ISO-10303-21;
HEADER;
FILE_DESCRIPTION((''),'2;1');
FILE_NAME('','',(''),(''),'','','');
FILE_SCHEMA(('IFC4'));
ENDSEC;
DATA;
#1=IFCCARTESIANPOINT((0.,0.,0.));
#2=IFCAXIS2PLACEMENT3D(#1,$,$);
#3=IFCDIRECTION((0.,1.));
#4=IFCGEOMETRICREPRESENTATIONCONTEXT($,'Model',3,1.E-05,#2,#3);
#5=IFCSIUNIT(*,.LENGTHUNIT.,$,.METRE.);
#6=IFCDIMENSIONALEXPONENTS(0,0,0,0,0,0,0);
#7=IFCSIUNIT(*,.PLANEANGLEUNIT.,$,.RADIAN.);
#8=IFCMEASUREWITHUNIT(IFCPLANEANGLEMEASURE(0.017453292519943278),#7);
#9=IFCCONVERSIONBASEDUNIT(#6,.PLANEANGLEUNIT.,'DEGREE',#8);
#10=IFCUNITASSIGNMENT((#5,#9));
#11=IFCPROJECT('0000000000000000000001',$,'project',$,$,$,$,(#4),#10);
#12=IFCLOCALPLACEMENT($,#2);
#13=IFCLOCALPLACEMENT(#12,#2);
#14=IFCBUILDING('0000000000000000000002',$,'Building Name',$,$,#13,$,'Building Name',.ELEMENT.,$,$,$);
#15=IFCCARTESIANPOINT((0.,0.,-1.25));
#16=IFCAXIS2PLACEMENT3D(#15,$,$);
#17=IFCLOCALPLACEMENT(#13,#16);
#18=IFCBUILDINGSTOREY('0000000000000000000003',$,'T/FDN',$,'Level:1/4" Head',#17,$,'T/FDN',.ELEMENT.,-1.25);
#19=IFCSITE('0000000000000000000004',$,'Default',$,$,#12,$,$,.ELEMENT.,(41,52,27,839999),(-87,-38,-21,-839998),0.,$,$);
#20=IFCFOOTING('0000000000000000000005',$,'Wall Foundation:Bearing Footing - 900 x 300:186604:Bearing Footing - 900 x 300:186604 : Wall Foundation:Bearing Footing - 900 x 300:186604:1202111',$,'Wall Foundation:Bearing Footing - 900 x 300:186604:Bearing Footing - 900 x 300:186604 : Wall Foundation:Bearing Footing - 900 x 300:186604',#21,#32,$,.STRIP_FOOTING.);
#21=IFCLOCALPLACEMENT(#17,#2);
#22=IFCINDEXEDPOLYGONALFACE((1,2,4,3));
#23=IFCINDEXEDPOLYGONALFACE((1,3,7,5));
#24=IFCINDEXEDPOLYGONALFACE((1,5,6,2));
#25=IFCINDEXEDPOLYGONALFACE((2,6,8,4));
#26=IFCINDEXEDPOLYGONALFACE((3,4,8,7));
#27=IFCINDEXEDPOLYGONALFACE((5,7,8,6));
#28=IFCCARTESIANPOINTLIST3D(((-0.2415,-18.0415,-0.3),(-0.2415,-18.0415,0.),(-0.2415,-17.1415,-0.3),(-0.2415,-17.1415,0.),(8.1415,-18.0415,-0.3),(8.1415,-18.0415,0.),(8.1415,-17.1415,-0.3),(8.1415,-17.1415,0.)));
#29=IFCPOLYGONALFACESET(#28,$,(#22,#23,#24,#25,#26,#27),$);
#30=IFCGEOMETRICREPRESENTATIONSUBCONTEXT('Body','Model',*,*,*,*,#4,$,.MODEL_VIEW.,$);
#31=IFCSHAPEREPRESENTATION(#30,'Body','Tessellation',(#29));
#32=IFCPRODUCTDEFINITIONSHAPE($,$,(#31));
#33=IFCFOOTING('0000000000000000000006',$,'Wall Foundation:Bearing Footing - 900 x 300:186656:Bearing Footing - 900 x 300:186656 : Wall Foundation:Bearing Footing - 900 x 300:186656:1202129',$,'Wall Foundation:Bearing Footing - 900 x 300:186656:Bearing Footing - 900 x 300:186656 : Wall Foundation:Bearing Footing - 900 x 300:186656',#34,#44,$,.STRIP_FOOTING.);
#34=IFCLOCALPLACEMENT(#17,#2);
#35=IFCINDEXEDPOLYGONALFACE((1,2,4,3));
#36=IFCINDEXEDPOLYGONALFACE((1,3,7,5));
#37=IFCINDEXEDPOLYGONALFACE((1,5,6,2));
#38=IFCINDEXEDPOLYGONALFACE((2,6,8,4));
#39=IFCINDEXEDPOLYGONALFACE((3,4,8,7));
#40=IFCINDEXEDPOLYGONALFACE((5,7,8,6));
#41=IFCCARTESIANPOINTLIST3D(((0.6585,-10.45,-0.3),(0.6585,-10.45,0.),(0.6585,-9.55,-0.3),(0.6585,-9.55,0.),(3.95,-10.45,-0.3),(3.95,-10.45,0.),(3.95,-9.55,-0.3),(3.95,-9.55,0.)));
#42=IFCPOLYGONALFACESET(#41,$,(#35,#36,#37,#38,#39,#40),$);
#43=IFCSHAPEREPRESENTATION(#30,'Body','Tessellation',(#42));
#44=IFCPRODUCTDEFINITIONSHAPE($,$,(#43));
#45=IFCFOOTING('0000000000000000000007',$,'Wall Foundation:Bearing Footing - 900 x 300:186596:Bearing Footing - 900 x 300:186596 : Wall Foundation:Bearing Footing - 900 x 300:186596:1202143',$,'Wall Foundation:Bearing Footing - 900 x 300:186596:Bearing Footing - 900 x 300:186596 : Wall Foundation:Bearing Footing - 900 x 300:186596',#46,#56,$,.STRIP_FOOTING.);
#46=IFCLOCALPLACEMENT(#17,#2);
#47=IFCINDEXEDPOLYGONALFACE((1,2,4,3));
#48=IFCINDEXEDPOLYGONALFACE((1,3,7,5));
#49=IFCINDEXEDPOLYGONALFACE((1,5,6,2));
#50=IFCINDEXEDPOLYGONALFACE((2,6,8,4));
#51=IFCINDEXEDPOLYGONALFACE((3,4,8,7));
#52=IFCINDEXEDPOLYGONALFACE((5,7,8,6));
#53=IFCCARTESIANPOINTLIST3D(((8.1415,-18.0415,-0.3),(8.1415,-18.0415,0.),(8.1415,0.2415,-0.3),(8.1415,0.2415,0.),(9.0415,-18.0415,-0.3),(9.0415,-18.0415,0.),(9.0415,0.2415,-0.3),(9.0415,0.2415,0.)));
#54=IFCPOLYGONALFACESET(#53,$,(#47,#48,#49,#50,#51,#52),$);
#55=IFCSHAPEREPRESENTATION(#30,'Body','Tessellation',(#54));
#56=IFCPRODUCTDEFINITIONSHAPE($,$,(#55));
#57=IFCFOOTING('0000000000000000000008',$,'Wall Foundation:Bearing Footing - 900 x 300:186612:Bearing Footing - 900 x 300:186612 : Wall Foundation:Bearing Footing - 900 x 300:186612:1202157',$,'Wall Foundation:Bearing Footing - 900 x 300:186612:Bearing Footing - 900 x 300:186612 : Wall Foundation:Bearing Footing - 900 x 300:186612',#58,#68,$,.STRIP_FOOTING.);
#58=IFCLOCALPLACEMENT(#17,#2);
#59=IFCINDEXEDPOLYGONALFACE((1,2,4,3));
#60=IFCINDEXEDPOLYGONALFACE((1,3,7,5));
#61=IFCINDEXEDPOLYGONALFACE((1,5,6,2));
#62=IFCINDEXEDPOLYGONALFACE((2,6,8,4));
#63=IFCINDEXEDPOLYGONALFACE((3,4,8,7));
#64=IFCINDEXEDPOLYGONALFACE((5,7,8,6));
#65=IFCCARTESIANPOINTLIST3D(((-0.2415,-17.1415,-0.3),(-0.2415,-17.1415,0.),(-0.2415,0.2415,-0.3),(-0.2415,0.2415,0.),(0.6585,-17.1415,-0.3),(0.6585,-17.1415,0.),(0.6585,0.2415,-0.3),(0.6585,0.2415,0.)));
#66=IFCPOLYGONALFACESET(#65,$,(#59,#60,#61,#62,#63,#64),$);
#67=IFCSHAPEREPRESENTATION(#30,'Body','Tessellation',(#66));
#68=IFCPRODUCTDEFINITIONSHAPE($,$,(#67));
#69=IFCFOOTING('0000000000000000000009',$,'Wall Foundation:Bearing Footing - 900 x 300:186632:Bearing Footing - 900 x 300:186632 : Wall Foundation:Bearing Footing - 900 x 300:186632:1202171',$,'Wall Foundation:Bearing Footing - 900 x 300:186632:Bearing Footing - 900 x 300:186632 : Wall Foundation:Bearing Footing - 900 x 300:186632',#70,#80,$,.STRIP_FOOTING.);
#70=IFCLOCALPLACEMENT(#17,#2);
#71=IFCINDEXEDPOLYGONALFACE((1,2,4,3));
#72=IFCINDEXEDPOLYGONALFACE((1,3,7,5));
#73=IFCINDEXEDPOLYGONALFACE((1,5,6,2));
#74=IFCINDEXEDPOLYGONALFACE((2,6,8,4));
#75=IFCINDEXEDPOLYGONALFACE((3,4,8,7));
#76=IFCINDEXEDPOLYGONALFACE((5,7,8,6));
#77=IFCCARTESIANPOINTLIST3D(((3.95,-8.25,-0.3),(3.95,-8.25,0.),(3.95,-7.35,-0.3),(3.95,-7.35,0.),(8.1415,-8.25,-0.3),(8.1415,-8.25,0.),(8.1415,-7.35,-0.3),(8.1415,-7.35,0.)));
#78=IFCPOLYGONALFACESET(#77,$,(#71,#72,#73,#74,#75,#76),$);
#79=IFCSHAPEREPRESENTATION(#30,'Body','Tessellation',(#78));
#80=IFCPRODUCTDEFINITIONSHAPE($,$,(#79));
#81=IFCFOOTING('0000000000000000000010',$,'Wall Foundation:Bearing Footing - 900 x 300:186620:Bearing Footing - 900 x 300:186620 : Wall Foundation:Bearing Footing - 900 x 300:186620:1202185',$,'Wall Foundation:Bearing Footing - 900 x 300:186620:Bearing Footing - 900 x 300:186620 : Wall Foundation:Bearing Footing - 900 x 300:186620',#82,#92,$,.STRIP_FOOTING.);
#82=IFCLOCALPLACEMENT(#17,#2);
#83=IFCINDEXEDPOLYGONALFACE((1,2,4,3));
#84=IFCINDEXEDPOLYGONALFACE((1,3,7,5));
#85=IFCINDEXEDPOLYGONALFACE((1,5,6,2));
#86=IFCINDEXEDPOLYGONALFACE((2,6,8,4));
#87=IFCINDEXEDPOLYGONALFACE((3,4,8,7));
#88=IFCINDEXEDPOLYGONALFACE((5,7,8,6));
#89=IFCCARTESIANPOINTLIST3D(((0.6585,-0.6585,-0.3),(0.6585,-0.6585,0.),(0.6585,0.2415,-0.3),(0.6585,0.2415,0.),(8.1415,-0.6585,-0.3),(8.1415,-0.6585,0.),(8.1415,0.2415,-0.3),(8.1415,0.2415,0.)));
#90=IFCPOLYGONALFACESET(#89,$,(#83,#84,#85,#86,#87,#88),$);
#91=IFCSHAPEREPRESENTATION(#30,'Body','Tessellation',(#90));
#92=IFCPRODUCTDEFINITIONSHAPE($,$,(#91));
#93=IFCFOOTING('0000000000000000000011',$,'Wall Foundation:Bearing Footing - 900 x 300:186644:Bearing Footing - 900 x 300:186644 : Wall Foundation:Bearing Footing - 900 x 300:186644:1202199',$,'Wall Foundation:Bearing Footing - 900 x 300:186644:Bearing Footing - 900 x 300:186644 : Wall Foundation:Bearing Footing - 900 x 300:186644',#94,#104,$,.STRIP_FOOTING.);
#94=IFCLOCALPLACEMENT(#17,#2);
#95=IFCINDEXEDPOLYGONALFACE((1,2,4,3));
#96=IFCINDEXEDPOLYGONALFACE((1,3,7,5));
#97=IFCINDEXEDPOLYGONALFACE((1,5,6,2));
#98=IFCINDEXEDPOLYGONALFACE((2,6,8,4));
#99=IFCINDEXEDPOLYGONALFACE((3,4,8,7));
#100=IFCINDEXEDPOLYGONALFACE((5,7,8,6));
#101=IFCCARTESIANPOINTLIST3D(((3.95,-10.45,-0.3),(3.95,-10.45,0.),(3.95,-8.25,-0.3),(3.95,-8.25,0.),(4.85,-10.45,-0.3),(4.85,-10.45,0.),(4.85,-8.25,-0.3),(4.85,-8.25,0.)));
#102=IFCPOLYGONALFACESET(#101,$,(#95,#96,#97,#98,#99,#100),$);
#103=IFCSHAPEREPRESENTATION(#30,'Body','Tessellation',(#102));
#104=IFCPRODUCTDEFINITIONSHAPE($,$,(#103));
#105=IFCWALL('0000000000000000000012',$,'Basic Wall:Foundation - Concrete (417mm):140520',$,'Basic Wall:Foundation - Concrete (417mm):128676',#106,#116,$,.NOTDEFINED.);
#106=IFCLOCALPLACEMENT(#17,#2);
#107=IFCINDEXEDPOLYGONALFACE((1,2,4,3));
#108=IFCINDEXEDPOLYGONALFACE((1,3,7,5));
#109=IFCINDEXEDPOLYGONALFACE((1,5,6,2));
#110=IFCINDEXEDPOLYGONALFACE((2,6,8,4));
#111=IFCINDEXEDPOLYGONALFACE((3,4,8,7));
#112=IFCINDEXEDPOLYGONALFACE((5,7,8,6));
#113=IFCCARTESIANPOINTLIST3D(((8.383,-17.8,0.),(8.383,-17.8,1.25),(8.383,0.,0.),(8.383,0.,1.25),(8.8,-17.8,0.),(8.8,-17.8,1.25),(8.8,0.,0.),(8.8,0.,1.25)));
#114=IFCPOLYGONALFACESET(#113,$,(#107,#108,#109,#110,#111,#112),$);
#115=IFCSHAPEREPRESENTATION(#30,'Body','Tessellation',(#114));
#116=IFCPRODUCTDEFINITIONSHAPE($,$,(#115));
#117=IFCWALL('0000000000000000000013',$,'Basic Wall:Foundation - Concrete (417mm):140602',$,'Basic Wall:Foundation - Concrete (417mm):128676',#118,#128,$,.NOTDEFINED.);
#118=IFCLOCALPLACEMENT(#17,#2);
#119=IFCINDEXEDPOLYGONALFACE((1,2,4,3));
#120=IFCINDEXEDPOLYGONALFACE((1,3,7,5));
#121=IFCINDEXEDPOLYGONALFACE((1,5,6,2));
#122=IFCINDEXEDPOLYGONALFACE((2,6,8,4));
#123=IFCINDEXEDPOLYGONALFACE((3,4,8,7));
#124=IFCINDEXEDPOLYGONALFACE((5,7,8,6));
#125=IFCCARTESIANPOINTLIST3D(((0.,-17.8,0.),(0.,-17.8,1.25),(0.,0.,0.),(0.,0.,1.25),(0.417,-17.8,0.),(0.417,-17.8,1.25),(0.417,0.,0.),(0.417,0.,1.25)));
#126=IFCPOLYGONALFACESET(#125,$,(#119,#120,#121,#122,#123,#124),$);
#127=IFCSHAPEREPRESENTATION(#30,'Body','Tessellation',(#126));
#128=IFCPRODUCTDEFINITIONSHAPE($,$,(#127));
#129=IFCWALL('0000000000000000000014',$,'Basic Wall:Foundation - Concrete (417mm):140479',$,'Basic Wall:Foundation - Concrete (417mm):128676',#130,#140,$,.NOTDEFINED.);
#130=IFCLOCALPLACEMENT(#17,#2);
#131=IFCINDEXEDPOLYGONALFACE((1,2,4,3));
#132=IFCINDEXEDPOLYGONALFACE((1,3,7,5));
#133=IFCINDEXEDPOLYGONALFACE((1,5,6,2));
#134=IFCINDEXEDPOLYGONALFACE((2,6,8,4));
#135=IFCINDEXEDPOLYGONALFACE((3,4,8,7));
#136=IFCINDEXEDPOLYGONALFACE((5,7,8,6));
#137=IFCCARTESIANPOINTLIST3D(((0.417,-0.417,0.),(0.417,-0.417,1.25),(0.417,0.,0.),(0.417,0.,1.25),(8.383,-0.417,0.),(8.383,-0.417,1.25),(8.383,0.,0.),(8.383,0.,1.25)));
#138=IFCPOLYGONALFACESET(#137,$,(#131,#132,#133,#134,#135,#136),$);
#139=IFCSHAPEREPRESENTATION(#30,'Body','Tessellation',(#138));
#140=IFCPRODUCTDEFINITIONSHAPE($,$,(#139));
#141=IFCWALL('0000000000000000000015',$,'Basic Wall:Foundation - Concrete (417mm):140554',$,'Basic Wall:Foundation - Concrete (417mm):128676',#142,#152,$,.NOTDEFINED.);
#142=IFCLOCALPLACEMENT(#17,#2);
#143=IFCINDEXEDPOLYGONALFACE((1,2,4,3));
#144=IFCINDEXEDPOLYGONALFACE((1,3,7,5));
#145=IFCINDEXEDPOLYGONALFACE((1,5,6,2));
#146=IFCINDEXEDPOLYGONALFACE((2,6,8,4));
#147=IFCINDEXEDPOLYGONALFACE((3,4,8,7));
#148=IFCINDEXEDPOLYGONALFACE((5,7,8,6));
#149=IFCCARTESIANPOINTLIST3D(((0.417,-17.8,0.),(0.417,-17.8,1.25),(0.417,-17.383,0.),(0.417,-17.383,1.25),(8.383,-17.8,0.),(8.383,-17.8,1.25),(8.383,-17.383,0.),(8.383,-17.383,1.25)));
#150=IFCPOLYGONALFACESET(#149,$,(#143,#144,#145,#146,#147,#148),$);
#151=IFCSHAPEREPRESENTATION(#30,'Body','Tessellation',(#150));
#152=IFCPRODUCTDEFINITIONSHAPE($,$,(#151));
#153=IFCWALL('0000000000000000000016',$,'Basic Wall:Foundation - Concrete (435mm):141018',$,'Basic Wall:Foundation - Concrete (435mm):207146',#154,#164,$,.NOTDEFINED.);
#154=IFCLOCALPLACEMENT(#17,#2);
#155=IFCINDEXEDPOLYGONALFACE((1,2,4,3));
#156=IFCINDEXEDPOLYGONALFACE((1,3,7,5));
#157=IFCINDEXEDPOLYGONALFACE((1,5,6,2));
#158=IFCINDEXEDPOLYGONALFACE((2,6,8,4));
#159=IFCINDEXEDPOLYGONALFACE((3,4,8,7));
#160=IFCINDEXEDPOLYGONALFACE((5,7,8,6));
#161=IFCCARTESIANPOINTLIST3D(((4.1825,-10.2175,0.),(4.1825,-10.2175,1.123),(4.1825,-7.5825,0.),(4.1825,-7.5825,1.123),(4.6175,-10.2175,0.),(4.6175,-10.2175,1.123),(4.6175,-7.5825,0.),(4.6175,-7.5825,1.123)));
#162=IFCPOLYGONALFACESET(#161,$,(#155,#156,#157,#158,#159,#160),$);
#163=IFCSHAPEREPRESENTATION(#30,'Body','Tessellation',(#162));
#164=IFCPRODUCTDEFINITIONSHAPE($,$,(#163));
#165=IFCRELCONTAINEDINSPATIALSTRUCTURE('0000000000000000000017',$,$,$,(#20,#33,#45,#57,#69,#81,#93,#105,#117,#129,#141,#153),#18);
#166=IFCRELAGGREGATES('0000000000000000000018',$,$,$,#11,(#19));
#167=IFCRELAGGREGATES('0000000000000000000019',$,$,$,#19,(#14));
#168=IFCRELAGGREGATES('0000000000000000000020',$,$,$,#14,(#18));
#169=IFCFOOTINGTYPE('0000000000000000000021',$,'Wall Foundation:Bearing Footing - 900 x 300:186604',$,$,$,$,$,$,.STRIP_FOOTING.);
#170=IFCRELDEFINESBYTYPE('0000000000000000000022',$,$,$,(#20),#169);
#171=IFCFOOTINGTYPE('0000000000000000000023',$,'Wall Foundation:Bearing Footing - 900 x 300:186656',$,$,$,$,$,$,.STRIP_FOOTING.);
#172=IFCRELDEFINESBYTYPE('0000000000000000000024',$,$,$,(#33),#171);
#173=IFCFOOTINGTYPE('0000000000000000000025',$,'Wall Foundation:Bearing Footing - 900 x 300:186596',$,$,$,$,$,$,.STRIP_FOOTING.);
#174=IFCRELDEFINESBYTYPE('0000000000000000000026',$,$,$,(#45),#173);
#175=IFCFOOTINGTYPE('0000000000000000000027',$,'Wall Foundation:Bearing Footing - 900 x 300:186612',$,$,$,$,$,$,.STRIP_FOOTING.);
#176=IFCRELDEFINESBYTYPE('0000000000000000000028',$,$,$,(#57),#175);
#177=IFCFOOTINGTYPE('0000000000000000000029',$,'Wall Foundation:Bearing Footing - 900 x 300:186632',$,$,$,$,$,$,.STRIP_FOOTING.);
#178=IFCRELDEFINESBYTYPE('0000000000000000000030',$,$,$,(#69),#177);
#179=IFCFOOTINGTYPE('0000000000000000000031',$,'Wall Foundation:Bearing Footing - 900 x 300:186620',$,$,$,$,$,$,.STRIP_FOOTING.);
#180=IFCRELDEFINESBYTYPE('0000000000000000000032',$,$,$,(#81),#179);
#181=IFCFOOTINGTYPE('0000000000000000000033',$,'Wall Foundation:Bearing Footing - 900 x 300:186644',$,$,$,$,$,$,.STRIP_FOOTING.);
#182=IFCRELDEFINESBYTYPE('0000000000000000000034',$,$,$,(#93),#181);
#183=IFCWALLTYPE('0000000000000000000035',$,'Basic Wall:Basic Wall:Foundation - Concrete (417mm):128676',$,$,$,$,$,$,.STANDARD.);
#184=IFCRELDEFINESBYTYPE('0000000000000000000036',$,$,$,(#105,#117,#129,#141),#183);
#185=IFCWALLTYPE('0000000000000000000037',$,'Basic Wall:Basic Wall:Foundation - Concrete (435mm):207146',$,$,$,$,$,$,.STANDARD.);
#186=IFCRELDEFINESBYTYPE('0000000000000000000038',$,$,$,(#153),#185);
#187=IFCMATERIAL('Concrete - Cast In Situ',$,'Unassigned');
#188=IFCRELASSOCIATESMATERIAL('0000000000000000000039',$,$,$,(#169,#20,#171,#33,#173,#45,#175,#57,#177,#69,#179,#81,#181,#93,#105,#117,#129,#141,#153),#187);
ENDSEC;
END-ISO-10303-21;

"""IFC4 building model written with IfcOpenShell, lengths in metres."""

from ifc_helpers import new_model, entity, si_unit, converted_unit, direction, frame, origin, place, context, subcontext, project, spatial, indexed_curve, outline, extrude, source, transform, mapped, material, type_object, type_shapes, element, save


model = new_model("IFC4")

# Units and contexts
model_context = context("Model", 3, precision=1e-05, world=origin(), true_north=direction((0.0, 1.0)))
body_context = subcontext(model_context, "Body", "Model", "MODEL_VIEW")
ifc_project = project(units=[si_unit("LENGTHUNIT", "METRE"), converted_unit("PLANEANGLEUNIT", "DEGREE", entity("IfcPlaneAngleMeasure", 0.017453292519943278), si_unit("PLANEANGLEUNIT", "RADIAN"), dimensions=[0, 0, 0, 0, 0, 0, 0])], contexts=[model_context])

# Site, building, storey
site_placement = place(None, origin())
site = spatial("IfcSite", under=ifc_project, at=site_placement, Name="Default", CompositionType="ELEMENT", RefLatitude=(41, 52, 27, 839999), RefLongitude=(-87, -38, -21, -839998), RefElevation=0.0)
building_placement = place(site_placement, origin())
building = spatial("IfcBuilding", under=site, at=building_placement, Name="Building Name", LongName="Building Name", CompositionType="ELEMENT")
storey_placement = place(building_placement, frame((0.0, 0.0, -1.25)))
storey = spatial("IfcBuildingStorey", under=building, at=storey_placement, Name="T/FDN", ObjectType="Level:1/4\" Head", LongName="T/FDN", CompositionType="ELEMENT", Elevation=-1.25)

# Footings
ifc_material = material(Name="Concrete - Cast In Situ", Category="Unassigned")
footing_type_1 = type_object("IfcFootingType", Name="Wall Foundation:Bearing Footing - 900 x 300:186604", PredefinedType="STRIP_FOOTING", material=ifc_material)
shared_shape_1 = source(origin(), body_context, "Body", "SweptSolid", [
    extrude(outline(indexed_curve([(-0.45, -4.1915), (0.45, -4.1915), (0.45, 4.1915), (-0.45, 4.1915), (-0.45, -4.1915)], self_intersect=False)), frame((3.95, -17.5915, -1.55), z_axis=(0.0, 0.0, 1.0), x_axis=(0.0, 1.0, 0.0)), (0.0, 0.0, 1.0), 0.3),
])
type_shapes(footing_type_1, [shared_shape_1])
footing_1_placement = place(storey_placement, frame((0.0, 0.0, 1.25)))
element("IfcFooting", 1, at=footing_1_placement, inside=storey, type_object=footing_type_1, material=ifc_material, Name="Wall Foundation:Bearing Footing - 900 x 300:186604:Bearing Footing - 900 x 300:186604 : Wall Foundation:Bearing Footing - 900 x 300:186604:1202111", ObjectType="Wall Foundation:Bearing Footing - 900 x 300:186604:Bearing Footing - 900 x 300:186604 : Wall Foundation:Bearing Footing - 900 x 300:186604", PredefinedType="STRIP_FOOTING", context=body_context, shape_type="MappedRepresentation", body=[
    mapped(shared_shape_1, transform((0.0, 0.0, 0.0), scale=1.0)),
])
footing_type_2 = type_object("IfcFootingType", Name="Wall Foundation:Bearing Footing - 900 x 300:186656", PredefinedType="STRIP_FOOTING", material=ifc_material)
shared_shape_2 = source(origin(), body_context, "Body", "SweptSolid", [
    extrude(outline(indexed_curve([(-0.45, -1.6457), (0.45, -1.6457), (0.45, 1.6457), (-0.45, 1.6457), (-0.45, -1.6457)], self_intersect=False)), frame((2.3042, -10.0, -1.55), z_axis=(0.0, 0.0, 1.0), x_axis=(0.0, 1.0, 0.0)), (0.0, 0.0, 1.0), 0.3),
])
type_shapes(footing_type_2, [shared_shape_2])
footing_2_placement = place(storey_placement, frame((0.0, 0.0, 1.25)))
element("IfcFooting", 2, at=footing_2_placement, inside=storey, type_object=footing_type_2, material=ifc_material, Name="Wall Foundation:Bearing Footing - 900 x 300:186656:Bearing Footing - 900 x 300:186656 : Wall Foundation:Bearing Footing - 900 x 300:186656:1202129", ObjectType="Wall Foundation:Bearing Footing - 900 x 300:186656:Bearing Footing - 900 x 300:186656 : Wall Foundation:Bearing Footing - 900 x 300:186656", PredefinedType="STRIP_FOOTING", context=body_context, shape_type="MappedRepresentation", body=[
    mapped(shared_shape_2, transform((0.0, 0.0, 0.0), scale=1.0)),
])
footing_type_3 = type_object("IfcFootingType", Name="Wall Foundation:Bearing Footing - 900 x 300:186596", PredefinedType="STRIP_FOOTING", material=ifc_material)
shared_shape_3 = source(origin(), body_context, "Body", "SweptSolid", [
    extrude(outline(indexed_curve([(-0.45, -9.1415), (0.45, -9.1415), (0.45, 9.1415), (-0.45, 9.1415), (-0.45, -9.1415)], self_intersect=False)), frame((8.5915, -8.9, -1.55)), (0.0, 0.0, 1.0), 0.3),
])
type_shapes(footing_type_3, [shared_shape_3])
footing_3_placement = place(storey_placement, frame((0.0, 0.0, 1.25)))
element("IfcFooting", 3, at=footing_3_placement, inside=storey, type_object=footing_type_3, material=ifc_material, Name="Wall Foundation:Bearing Footing - 900 x 300:186596:Bearing Footing - 900 x 300:186596 : Wall Foundation:Bearing Footing - 900 x 300:186596:1202143", ObjectType="Wall Foundation:Bearing Footing - 900 x 300:186596:Bearing Footing - 900 x 300:186596 : Wall Foundation:Bearing Footing - 900 x 300:186596", PredefinedType="STRIP_FOOTING", context=body_context, shape_type="MappedRepresentation", body=[
    mapped(shared_shape_3, transform((0.0, 0.0, 0.0), scale=1.0)),
])
footing_type_4 = type_object("IfcFootingType", Name="Wall Foundation:Bearing Footing - 900 x 300:186612", PredefinedType="STRIP_FOOTING", material=ifc_material)
shared_shape_4 = source(origin(), body_context, "Body", "SweptSolid", [
    extrude(outline(indexed_curve([(-0.45, -8.6915), (0.45, -8.6915), (0.45, 8.6915), (-0.45, 8.6915), (-0.45, -8.6915)], self_intersect=False)), frame((0.2085, -8.45, -1.55)), (0.0, 0.0, 1.0), 0.3),
])
type_shapes(footing_type_4, [shared_shape_4])
footing_4_placement = place(storey_placement, frame((0.0, 0.0, 1.25)))
element("IfcFooting", 4, at=footing_4_placement, inside=storey, type_object=footing_type_4, material=ifc_material, Name="Wall Foundation:Bearing Footing - 900 x 300:186612:Bearing Footing - 900 x 300:186612 : Wall Foundation:Bearing Footing - 900 x 300:186612:1202157", ObjectType="Wall Foundation:Bearing Footing - 900 x 300:186612:Bearing Footing - 900 x 300:186612 : Wall Foundation:Bearing Footing - 900 x 300:186612", PredefinedType="STRIP_FOOTING", context=body_context, shape_type="MappedRepresentation", body=[
    mapped(shared_shape_4, transform((0.0, 0.0, 0.0), scale=1.0)),
])
footing_type_5 = type_object("IfcFootingType", Name="Wall Foundation:Bearing Footing - 900 x 300:186632", PredefinedType="STRIP_FOOTING", material=ifc_material)
shared_shape_5 = source(origin(), body_context, "Body", "SweptSolid", [
    extrude(outline(indexed_curve([(-0.45, -2.0958), (0.45, -2.0958), (0.45, 2.0958), (-0.45, 2.0958), (-0.45, -2.0958)], self_intersect=False)), frame((6.0457, -7.8, -1.55), z_axis=(0.0, 0.0, 1.0), x_axis=(0.0, -1.0, 0.0)), (0.0, 0.0, 1.0), 0.3),
])
type_shapes(footing_type_5, [shared_shape_5])
footing_5_placement = place(storey_placement, frame((0.0, 0.0, 1.25)))
element("IfcFooting", 5, at=footing_5_placement, inside=storey, type_object=footing_type_5, material=ifc_material, Name="Wall Foundation:Bearing Footing - 900 x 300:186632:Bearing Footing - 900 x 300:186632 : Wall Foundation:Bearing Footing - 900 x 300:186632:1202171", ObjectType="Wall Foundation:Bearing Footing - 900 x 300:186632:Bearing Footing - 900 x 300:186632 : Wall Foundation:Bearing Footing - 900 x 300:186632", PredefinedType="STRIP_FOOTING", context=body_context, shape_type="MappedRepresentation", body=[
    mapped(shared_shape_5, transform((0.0, 0.0, 0.0), scale=1.0)),
])
footing_type_6 = type_object("IfcFootingType", Name="Wall Foundation:Bearing Footing - 900 x 300:186620", PredefinedType="STRIP_FOOTING", material=ifc_material)
shared_shape_6 = source(origin(), body_context, "Body", "SweptSolid", [
    extrude(outline(indexed_curve([(-0.45, -3.7415), (0.45, -3.7415), (0.45, 3.7415), (-0.45, 3.7415), (-0.45, -3.7415)], self_intersect=False)), frame((4.4, -0.2085, -1.55), z_axis=(0.0, 0.0, 1.0), x_axis=(0.0, -1.0, 0.0)), (0.0, 0.0, 1.0), 0.3),
])
type_shapes(footing_type_6, [shared_shape_6])
footing_6_placement = place(storey_placement, frame((0.0, 0.0, 1.25)))
element("IfcFooting", 6, at=footing_6_placement, inside=storey, type_object=footing_type_6, material=ifc_material, Name="Wall Foundation:Bearing Footing - 900 x 300:186620:Bearing Footing - 900 x 300:186620 : Wall Foundation:Bearing Footing - 900 x 300:186620:1202185", ObjectType="Wall Foundation:Bearing Footing - 900 x 300:186620:Bearing Footing - 900 x 300:186620 : Wall Foundation:Bearing Footing - 900 x 300:186620", PredefinedType="STRIP_FOOTING", context=body_context, shape_type="MappedRepresentation", body=[
    mapped(shared_shape_6, transform((0.0, 0.0, 0.0), scale=1.0)),
])
footing_type_7 = type_object("IfcFootingType", Name="Wall Foundation:Bearing Footing - 900 x 300:186644", PredefinedType="STRIP_FOOTING", material=ifc_material)
shared_shape_7 = source(origin(), body_context, "Body", "SweptSolid", [
    extrude(outline(indexed_curve([(-0.45, -1.1), (0.45, -1.1), (0.45, 1.1), (-0.45, 1.1), (-0.45, -1.1)], self_intersect=False)), frame((4.4, -9.35, -1.55), z_axis=(0.0, 0.0, 1.0), x_axis=(-1.0, 0.0, 0.0)), (0.0, 0.0, 1.0), 0.3),
])
type_shapes(footing_type_7, [shared_shape_7])
footing_7_placement = place(storey_placement, frame((0.0, 0.0, 1.25)))
element("IfcFooting", 7, at=footing_7_placement, inside=storey, type_object=footing_type_7, material=ifc_material, Name="Wall Foundation:Bearing Footing - 900 x 300:186644:Bearing Footing - 900 x 300:186644 : Wall Foundation:Bearing Footing - 900 x 300:186644:1202199", ObjectType="Wall Foundation:Bearing Footing - 900 x 300:186644:Bearing Footing - 900 x 300:186644 : Wall Foundation:Bearing Footing - 900 x 300:186644", PredefinedType="STRIP_FOOTING", context=body_context, shape_type="MappedRepresentation", body=[
    mapped(shared_shape_7, transform((0.0, 0.0, 0.0), scale=1.0)),
])

# Walls
wall_type_1 = type_object("IfcWallType", Name="Basic Wall:Basic Wall:Foundation - Concrete (417mm):128676", PredefinedType="STANDARD")
wall_1_placement = place(storey_placement, frame((8.5915, 0.0, 0.0), z_axis=(0.0, 0.0, 1.0), x_axis=(0.0, -1.0, 0.0)))
element("IfcWall", 8, at=wall_1_placement, inside=storey, type_object=wall_type_1, material=ifc_material, Name="Basic Wall:Foundation - Concrete (417mm):140520", ObjectType="Basic Wall:Foundation - Concrete (417mm):128676", PredefinedType="NOTDEFINED", context=body_context, shape_type="SweptSolid", body=[
    extrude(outline(indexed_curve([(17.8, 0.2085), (0.0, 0.2085), (0.0, -0.2085), (17.8, -0.2085), (17.8, 0.2085)], self_intersect=False)), origin(), (0.0, 0.0, 1.0), 1.25),
])
wall_2_placement = place(storey_placement, frame((0.2085, -17.8, 0.0), z_axis=(0.0, 0.0, 1.0), x_axis=(0.0, 1.0, 0.0)))
element("IfcWall", 9, at=wall_2_placement, inside=storey, type_object=wall_type_1, material=ifc_material, Name="Basic Wall:Foundation - Concrete (417mm):140602", ObjectType="Basic Wall:Foundation - Concrete (417mm):128676", PredefinedType="NOTDEFINED", context=body_context, shape_type="SweptSolid", body=[
    extrude(outline(indexed_curve([(17.8, 0.2085), (0.0, 0.2085), (0.0, -0.2085), (17.8, -0.2085), (17.8, 0.2085)], self_intersect=False)), origin(), (0.0, 0.0, 1.0), 1.25),
])
wall_3_placement = place(storey_placement, frame((0.417, -0.2085, 0.0)))
element("IfcWall", 10, at=wall_3_placement, inside=storey, type_object=wall_type_1, material=ifc_material, Name="Basic Wall:Foundation - Concrete (417mm):140479", ObjectType="Basic Wall:Foundation - Concrete (417mm):128676", PredefinedType="NOTDEFINED", context=body_context, shape_type="SweptSolid", body=[
    extrude(outline(indexed_curve([(7.966, 0.2085), (0.0, 0.2085), (0.0, -0.2085), (7.966, -0.2085), (7.966, 0.2085)], self_intersect=False)), origin(), (0.0, 0.0, 1.0), 1.25),
])
wall_4_placement = place(storey_placement, frame((8.383, -17.5915, 0.0), z_axis=(0.0, 0.0, 1.0), x_axis=(-1.0, 0.0, 0.0)))
element("IfcWall", 11, at=wall_4_placement, inside=storey, type_object=wall_type_1, material=ifc_material, Name="Basic Wall:Foundation - Concrete (417mm):140554", ObjectType="Basic Wall:Foundation - Concrete (417mm):128676", PredefinedType="NOTDEFINED", context=body_context, shape_type="SweptSolid", body=[
    extrude(outline(indexed_curve([(7.966, 0.2085), (0.0, 0.2085), (0.0, -0.2085), (7.966, -0.2085), (7.966, 0.2085)], self_intersect=False)), origin(), (0.0, 0.0, 1.0), 1.25),
])
wall_type_2 = type_object("IfcWallType", Name="Basic Wall:Basic Wall:Foundation - Concrete (435mm):207146", PredefinedType="STANDARD")
wall_5_placement = place(storey_placement, frame((4.4, -10.2175, 0.0), z_axis=(0.0, 0.0, 1.0), x_axis=(0.0, 1.0, 0.0)))
element("IfcWall", 12, at=wall_5_placement, inside=storey, type_object=wall_type_2, material=ifc_material, Name="Basic Wall:Foundation - Concrete (435mm):141018", ObjectType="Basic Wall:Foundation - Concrete (435mm):207146", PredefinedType="NOTDEFINED", context=body_context, shape_type="SweptSolid", body=[
    extrude(outline(indexed_curve([(2.635, 0.2175), (0.0, 0.2175), (0.0, -0.2175), (2.635, -0.2175), (2.635, 0.2175)], self_intersect=False)), origin(), (0.0, 0.0, 1.0), 1.123),
])

save(model, "model.ifc")
